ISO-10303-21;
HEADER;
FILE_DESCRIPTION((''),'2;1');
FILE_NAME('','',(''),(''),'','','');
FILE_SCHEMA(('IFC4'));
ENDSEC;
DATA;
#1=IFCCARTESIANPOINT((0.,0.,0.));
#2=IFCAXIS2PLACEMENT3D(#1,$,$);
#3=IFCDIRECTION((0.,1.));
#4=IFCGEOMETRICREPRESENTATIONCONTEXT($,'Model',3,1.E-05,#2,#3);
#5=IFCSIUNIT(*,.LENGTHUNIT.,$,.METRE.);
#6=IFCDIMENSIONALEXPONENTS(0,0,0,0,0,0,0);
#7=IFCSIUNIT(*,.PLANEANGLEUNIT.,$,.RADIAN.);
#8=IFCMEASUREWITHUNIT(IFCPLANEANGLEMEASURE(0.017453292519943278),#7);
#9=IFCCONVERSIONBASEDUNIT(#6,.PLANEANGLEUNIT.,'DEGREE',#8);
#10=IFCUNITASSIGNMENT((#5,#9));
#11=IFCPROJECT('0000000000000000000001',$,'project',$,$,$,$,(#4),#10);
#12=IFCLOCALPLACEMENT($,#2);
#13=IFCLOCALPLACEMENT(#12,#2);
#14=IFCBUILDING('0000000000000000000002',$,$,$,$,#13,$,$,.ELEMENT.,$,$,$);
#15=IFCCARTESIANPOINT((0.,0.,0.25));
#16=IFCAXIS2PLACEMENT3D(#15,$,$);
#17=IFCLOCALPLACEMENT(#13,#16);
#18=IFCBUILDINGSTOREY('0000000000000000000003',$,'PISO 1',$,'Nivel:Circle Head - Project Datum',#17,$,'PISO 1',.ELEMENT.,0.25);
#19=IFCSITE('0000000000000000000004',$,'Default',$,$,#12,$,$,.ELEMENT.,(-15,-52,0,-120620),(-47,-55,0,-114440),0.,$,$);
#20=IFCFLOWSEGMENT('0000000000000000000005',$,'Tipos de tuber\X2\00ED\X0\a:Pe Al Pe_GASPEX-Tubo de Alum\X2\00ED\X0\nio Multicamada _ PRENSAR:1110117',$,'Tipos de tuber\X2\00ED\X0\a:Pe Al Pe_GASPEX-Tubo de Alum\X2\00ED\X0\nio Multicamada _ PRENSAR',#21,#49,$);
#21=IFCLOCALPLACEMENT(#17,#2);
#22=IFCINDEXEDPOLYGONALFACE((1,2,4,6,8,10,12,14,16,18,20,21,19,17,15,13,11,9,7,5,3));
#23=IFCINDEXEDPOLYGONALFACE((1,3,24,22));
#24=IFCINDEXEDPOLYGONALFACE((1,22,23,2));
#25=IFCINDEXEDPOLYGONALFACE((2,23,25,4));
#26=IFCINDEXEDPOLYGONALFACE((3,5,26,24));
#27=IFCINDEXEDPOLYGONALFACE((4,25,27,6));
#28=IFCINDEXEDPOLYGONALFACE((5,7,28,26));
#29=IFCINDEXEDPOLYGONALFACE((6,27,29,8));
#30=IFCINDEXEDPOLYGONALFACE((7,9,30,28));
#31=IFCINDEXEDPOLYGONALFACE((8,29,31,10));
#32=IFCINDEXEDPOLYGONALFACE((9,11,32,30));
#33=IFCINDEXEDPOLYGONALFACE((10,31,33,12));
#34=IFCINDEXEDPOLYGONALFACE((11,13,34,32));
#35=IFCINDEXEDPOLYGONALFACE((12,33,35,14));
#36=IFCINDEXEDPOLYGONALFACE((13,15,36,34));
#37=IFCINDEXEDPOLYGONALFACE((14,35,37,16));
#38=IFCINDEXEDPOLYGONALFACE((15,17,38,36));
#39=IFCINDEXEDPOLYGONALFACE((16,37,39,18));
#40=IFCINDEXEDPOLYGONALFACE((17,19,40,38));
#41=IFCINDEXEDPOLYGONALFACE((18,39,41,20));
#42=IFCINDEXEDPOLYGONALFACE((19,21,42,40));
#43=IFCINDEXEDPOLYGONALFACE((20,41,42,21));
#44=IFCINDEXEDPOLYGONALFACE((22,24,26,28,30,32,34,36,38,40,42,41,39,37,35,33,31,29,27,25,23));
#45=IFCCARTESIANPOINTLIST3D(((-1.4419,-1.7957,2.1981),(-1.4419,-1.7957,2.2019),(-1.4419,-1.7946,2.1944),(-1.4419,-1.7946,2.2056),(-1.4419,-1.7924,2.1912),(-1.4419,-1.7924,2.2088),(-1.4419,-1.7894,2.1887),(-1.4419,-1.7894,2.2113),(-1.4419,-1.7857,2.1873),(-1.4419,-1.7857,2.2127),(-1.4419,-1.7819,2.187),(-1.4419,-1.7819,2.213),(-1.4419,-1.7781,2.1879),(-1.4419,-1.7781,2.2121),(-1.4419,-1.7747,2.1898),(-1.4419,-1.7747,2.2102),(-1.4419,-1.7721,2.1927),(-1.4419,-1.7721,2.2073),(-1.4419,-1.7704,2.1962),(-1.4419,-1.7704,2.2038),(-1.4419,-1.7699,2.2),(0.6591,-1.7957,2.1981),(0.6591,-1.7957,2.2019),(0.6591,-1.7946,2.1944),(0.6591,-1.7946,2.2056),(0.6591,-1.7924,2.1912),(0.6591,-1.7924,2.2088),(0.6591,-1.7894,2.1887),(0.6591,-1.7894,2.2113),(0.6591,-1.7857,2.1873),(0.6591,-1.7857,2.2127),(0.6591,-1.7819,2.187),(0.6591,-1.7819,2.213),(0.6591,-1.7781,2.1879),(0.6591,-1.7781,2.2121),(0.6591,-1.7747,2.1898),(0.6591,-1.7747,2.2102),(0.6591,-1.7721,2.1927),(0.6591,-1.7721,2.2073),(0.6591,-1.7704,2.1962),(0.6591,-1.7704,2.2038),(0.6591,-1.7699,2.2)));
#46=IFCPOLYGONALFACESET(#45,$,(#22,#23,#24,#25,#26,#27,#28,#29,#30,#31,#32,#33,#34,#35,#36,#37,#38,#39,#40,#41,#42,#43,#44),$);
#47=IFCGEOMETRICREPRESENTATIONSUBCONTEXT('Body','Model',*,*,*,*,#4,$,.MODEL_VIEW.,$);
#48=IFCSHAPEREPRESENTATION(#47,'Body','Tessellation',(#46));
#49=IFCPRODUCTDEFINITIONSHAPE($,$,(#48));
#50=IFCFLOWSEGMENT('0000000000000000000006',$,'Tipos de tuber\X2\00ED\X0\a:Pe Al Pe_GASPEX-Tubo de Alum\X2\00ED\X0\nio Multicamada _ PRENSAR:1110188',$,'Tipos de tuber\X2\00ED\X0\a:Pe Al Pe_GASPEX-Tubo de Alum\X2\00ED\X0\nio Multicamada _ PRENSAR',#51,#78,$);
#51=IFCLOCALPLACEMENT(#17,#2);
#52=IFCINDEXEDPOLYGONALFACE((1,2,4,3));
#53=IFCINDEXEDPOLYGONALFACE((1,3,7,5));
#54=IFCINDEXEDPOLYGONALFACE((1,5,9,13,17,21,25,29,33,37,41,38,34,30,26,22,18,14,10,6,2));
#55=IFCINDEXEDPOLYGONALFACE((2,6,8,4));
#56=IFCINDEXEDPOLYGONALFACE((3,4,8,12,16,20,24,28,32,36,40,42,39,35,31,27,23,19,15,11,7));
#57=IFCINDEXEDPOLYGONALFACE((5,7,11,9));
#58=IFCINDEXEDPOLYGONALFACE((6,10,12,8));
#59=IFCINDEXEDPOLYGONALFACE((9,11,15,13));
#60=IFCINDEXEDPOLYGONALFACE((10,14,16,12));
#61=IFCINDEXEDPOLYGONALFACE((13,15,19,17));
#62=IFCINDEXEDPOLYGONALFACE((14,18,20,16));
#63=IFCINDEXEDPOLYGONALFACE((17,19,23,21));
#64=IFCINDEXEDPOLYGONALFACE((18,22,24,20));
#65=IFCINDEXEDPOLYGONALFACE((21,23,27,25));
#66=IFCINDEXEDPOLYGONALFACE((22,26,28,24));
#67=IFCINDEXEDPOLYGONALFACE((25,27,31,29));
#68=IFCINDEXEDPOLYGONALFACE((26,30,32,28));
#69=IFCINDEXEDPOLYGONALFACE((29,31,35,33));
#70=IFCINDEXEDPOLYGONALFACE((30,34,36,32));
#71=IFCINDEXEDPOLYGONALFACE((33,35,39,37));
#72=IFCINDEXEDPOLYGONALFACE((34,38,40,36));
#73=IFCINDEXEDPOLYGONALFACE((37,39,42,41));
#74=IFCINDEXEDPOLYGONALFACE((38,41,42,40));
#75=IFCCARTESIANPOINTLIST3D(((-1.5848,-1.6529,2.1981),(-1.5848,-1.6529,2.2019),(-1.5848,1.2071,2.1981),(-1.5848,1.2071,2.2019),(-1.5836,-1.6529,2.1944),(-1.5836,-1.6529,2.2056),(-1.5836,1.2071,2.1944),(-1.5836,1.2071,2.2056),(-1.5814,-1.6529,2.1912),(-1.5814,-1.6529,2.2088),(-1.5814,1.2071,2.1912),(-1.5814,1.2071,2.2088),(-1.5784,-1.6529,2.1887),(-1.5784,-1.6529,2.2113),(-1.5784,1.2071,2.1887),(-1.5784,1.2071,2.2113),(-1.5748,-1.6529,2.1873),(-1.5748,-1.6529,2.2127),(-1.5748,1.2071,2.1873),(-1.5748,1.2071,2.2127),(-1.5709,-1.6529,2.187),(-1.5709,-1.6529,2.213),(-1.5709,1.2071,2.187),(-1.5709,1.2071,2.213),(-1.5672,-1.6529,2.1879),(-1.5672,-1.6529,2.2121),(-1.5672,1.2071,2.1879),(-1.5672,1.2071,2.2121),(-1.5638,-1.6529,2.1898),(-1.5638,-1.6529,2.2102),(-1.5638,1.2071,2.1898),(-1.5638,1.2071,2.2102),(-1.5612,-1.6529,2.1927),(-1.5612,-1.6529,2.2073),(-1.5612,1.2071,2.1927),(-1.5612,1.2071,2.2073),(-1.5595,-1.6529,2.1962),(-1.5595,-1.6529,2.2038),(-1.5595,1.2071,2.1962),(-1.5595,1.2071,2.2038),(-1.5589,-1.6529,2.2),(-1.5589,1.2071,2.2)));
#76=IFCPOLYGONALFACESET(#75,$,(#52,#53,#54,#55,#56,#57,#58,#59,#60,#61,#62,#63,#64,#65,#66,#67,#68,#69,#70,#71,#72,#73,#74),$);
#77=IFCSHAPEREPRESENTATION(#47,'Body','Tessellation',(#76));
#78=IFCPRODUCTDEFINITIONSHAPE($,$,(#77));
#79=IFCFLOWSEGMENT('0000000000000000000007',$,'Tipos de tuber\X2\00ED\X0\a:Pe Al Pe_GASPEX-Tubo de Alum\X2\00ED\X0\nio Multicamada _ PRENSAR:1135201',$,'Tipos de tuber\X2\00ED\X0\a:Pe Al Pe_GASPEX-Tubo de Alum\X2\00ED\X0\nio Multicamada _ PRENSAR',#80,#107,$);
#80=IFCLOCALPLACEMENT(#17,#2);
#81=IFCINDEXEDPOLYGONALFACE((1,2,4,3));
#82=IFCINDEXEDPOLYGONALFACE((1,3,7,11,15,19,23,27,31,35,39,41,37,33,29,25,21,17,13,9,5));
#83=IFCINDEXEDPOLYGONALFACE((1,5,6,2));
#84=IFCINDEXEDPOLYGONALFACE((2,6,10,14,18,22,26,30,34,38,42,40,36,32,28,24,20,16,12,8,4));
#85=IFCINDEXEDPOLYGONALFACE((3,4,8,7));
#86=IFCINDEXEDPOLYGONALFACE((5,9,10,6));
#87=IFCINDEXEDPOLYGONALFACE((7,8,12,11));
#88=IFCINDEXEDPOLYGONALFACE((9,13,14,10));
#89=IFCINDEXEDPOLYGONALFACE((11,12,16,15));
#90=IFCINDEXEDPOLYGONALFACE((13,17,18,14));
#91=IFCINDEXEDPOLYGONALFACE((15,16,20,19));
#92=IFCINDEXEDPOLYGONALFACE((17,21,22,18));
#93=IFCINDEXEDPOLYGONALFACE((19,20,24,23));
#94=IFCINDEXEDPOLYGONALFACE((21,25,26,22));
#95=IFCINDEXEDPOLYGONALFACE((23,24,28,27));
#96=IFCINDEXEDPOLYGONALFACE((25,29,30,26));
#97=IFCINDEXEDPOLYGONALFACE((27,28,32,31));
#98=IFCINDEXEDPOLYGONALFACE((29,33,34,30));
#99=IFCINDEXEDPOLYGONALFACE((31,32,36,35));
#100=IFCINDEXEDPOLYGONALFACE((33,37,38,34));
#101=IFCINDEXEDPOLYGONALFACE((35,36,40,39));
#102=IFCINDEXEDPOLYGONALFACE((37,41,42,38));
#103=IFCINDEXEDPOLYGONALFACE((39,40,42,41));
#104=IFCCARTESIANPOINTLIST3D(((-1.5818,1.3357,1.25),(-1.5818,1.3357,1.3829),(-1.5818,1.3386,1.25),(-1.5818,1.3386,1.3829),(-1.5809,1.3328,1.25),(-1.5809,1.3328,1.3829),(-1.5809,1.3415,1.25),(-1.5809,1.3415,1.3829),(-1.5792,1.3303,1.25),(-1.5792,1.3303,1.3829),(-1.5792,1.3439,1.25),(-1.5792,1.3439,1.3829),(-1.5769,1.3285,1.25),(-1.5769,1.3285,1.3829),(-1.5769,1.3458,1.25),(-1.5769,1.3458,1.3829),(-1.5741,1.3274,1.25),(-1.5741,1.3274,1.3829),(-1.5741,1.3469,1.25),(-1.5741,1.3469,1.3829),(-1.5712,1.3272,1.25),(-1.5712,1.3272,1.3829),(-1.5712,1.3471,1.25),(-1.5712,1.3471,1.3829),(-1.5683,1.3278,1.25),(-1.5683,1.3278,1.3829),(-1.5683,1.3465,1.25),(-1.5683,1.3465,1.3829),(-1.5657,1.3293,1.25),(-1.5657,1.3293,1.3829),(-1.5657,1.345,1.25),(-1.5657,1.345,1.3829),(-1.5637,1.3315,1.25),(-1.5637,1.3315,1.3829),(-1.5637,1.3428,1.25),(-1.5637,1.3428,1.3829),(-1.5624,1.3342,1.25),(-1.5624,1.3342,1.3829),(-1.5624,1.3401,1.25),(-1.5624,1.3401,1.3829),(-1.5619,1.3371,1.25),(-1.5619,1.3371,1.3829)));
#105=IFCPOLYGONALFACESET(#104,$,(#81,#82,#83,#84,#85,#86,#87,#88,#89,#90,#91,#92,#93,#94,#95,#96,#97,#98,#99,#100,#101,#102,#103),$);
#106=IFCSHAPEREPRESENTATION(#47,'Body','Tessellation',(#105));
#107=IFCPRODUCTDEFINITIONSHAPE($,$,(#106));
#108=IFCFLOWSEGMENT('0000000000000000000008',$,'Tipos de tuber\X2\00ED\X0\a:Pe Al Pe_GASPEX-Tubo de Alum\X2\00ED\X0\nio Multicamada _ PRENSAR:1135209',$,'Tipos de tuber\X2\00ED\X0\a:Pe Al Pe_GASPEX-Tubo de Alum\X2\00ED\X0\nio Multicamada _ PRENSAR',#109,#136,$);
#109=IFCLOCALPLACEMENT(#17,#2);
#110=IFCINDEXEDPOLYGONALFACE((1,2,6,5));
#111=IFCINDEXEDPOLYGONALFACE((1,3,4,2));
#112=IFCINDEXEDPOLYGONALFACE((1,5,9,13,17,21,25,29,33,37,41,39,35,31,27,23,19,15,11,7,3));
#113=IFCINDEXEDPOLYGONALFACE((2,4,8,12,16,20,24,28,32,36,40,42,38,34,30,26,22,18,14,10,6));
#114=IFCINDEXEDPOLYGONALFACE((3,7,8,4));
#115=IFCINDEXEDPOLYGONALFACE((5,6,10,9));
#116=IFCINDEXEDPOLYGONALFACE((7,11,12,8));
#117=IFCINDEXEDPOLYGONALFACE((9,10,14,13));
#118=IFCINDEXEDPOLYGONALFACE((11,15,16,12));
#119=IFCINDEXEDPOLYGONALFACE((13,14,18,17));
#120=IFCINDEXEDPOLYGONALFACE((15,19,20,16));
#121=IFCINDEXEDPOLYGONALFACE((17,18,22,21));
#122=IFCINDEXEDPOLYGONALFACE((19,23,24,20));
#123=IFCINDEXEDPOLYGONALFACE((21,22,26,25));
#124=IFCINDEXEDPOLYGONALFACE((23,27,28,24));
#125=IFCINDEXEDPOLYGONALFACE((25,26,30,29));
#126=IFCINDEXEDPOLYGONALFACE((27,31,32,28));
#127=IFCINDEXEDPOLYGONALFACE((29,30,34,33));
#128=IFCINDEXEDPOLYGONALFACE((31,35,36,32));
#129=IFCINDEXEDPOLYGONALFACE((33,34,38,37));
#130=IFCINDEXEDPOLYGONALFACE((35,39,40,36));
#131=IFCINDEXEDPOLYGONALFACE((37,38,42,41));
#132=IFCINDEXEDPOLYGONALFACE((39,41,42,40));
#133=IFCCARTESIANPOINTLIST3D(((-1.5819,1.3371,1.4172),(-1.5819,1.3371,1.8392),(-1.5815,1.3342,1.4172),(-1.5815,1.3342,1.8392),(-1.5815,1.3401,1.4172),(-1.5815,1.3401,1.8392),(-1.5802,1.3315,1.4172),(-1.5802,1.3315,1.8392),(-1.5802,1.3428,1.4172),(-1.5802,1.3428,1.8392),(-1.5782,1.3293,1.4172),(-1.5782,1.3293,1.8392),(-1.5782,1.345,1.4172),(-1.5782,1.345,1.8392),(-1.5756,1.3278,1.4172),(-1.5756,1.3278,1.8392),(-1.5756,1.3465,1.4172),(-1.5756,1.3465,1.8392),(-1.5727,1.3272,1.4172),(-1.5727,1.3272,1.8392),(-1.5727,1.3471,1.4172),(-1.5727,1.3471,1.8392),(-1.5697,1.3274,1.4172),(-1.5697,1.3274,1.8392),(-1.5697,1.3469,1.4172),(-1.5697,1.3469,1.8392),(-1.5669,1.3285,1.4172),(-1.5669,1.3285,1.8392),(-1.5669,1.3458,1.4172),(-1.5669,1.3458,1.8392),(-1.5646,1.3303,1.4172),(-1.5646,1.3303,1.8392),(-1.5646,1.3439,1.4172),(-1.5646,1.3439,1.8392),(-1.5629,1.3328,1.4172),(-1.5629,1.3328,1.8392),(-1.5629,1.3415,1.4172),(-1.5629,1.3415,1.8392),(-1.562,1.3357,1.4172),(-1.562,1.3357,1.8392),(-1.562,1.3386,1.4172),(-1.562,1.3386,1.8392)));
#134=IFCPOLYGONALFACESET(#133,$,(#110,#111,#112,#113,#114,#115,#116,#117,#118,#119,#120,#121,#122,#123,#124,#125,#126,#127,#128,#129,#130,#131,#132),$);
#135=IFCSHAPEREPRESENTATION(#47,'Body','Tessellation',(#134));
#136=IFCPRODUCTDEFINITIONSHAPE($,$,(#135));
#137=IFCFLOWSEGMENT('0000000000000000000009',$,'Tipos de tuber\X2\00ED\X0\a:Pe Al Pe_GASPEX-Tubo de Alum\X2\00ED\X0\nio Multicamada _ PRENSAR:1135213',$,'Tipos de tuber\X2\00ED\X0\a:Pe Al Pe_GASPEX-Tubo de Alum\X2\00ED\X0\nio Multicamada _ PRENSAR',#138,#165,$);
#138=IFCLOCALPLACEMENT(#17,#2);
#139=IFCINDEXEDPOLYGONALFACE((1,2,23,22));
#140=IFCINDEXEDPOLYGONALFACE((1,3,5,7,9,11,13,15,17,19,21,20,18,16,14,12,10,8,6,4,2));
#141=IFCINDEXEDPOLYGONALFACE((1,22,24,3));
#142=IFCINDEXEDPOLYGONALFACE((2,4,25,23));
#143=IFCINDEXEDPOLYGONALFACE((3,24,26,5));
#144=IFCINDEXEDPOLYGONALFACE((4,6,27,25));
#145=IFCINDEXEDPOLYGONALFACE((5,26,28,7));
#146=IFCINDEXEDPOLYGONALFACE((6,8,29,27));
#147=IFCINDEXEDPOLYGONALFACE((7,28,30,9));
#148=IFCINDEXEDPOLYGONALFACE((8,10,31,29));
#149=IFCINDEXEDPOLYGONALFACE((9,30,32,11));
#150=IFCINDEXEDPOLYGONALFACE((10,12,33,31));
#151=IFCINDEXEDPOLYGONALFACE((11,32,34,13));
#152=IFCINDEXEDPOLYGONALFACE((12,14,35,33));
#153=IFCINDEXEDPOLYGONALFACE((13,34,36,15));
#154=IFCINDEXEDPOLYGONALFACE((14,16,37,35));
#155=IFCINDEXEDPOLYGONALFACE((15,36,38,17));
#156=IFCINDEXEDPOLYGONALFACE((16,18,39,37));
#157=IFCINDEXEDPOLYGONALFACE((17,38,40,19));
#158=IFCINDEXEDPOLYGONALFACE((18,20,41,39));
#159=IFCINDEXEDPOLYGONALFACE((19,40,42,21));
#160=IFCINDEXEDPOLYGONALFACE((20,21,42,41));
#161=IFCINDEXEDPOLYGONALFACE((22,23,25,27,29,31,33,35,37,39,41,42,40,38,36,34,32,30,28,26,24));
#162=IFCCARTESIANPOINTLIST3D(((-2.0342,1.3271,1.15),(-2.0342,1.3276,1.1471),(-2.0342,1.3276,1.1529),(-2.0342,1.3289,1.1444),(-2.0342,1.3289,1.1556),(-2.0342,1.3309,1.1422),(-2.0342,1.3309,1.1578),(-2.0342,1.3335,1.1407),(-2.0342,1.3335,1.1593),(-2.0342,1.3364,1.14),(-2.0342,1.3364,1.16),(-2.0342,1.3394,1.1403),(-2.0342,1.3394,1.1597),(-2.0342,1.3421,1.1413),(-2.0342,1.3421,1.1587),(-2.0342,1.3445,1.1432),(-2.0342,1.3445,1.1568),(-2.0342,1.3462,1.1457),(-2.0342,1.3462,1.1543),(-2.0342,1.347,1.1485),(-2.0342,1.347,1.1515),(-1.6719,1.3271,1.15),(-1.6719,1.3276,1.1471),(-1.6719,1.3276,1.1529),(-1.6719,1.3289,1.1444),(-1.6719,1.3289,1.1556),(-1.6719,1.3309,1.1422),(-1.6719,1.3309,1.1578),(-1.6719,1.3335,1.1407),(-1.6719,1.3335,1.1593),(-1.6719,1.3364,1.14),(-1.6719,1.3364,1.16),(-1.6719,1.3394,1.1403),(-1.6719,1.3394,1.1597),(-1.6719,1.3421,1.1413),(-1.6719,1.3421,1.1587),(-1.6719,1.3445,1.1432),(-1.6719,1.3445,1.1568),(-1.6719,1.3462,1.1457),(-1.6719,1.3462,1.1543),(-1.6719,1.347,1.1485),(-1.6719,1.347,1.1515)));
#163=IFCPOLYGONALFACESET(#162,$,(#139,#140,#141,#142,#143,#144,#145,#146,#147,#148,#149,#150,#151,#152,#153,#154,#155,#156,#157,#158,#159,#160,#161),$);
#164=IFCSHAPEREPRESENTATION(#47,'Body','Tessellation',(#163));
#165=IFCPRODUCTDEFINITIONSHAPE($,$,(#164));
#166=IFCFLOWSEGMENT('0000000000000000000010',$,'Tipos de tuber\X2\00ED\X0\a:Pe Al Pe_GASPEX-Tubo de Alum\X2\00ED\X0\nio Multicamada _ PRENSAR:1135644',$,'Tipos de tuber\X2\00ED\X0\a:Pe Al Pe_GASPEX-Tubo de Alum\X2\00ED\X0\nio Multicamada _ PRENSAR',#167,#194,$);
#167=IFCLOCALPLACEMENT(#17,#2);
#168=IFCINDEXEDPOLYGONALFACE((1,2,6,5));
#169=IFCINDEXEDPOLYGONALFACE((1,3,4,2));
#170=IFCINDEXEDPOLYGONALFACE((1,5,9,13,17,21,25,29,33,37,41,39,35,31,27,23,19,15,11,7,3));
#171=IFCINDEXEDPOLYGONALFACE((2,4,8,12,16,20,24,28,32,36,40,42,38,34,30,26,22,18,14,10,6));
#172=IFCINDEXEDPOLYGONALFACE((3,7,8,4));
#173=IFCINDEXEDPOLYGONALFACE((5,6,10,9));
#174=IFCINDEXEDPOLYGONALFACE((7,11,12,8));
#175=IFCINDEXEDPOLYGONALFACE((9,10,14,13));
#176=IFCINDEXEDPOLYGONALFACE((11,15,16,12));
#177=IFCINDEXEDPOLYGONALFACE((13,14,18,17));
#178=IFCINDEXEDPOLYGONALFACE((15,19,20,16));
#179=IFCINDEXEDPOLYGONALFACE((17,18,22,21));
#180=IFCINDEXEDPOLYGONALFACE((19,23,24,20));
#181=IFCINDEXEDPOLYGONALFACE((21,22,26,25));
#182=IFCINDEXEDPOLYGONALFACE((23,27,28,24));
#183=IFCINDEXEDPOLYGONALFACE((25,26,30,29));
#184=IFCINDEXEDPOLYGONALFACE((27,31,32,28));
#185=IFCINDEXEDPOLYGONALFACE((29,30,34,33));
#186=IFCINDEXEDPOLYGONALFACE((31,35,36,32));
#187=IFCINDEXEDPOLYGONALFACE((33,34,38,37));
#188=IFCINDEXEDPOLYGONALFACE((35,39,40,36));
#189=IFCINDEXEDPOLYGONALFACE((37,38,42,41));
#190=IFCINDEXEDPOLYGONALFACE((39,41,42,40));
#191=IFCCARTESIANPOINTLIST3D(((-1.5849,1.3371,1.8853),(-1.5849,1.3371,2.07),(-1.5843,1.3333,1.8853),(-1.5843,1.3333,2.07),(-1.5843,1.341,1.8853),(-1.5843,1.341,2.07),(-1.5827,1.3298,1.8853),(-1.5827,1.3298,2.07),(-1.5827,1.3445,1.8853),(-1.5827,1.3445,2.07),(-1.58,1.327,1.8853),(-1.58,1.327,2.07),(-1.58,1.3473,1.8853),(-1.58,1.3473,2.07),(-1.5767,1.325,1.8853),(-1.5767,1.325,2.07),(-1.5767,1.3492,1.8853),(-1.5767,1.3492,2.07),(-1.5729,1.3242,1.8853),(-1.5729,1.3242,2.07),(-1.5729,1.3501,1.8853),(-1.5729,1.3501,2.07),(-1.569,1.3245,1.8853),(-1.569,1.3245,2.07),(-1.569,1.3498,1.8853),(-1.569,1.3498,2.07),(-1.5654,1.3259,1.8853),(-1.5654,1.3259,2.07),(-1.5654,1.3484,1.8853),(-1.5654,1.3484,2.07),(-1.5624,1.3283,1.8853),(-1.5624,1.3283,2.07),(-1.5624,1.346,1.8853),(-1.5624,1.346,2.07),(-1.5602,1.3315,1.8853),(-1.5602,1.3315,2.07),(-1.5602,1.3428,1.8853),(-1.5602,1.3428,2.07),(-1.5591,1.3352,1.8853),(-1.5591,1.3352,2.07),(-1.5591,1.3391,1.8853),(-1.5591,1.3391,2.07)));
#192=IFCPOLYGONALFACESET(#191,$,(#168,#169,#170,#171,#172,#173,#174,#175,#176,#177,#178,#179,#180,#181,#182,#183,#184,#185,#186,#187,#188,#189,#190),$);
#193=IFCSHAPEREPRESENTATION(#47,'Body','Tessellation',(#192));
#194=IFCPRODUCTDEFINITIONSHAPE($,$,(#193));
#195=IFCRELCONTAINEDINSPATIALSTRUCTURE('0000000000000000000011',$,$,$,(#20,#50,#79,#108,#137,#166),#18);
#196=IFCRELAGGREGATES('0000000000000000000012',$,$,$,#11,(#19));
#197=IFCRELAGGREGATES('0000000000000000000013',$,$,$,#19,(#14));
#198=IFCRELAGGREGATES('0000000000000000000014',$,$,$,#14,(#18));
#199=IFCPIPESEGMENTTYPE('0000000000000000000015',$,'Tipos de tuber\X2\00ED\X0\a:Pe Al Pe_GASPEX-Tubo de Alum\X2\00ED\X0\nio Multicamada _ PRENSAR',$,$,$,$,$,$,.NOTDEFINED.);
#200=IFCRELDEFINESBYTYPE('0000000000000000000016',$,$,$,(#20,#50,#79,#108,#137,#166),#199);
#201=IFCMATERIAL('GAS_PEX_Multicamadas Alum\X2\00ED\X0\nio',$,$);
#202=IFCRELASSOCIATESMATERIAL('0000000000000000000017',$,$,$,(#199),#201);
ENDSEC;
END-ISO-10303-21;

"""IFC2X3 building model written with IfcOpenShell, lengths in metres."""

from ifc_helpers import new_model, entity, si_unit, converted_unit, direction, frame, frame_2d, origin, origin_2d_with_axis, place, context, subcontext, project, spatial, circle, extrude, material, type_object, element, save


model = new_model("IFC2X3")

# Units and contexts
model_context = context("Model", 3, precision=1e-05, world=origin(), true_north=direction((0.0, 1.0)))
body_context = subcontext(model_context, "Body", "Model", "MODEL_VIEW")
ifc_project = project(units=[si_unit("LENGTHUNIT", "METRE"), converted_unit("PLANEANGLEUNIT", "DEGREE", entity("IfcPlaneAngleMeasure", 0.017453292519943278), si_unit("PLANEANGLEUNIT", "RADIAN"), dimensions=[0, 0, 0, 0, 0, 0, 0])], contexts=[model_context])

# Site, building, storey
site_placement = place(None, origin())
site = spatial("IfcSite", under=ifc_project, at=site_placement, Name="Default", CompositionType="ELEMENT", RefLatitude=(-15, -52, 0, -120620), RefLongitude=(-47, -55, 0, -114440), RefElevation=0.0)
building_placement = place(site_placement, origin())
building = spatial("IfcBuilding", under=site, at=building_placement, CompositionType="ELEMENT")
storey_placement = place(building_placement, frame((0.0, 0.0, 0.25)))
storey = spatial("IfcBuildingStorey", under=building, at=storey_placement, Name="PISO 1", ObjectType="Nivel:Circle Head - Project Datum", LongName="PISO 1", CompositionType="ELEMENT", Elevation=0.25)

# Flow segments
ifc_material = material(Name="GAS_PEX_Multicamadas Alumínio")
pipe_segment_type = type_object("IfcPipeSegmentType", Name="Tipos de tubería:Pe Al Pe_GASPEX-Tubo de Alumínio Multicamada _ PRENSAR", PredefinedType="NOTDEFINED", material=ifc_material)
flow_segment_1_placement = place(storey_placement, origin())
element("IfcFlowSegment", 1, at=flow_segment_1_placement, inside=storey, type_object=pipe_segment_type, Name="Tipos de tubería:Pe Al Pe_GASPEX-Tubo de Alumínio Multicamada _ PRENSAR:1110117", ObjectType="Tipos de tubería:Pe Al Pe_GASPEX-Tubo de Alumínio Multicamada _ PRENSAR", context=body_context, shape_type="SweptSolid", body=[
    extrude(circle(Radius=0.013, at=origin_2d_with_axis()), frame((-1.4419, -1.7829, 2.2), z_axis=(1.0, 0.0, 0.0), x_axis=(0.0, 1.0, 0.0)), (0.0, 0.0, 1.0), 2.101),
])
flow_segment_2_placement = place(storey_placement, origin())
element("IfcFlowSegment", 2, at=flow_segment_2_placement, inside=storey, type_object=pipe_segment_type, Name="Tipos de tubería:Pe Al Pe_GASPEX-Tubo de Alumínio Multicamada _ PRENSAR:1110188", ObjectType="Tipos de tubería:Pe Al Pe_GASPEX-Tubo de Alumínio Multicamada _ PRENSAR", context=body_context, shape_type="SweptSolid", body=[
    extrude(circle(Radius=0.013, at=frame_2d((0.0, 0.0), x_axis=(1.0, 0.0))), frame((-1.5719, -1.6529, 2.2), z_axis=(0.0, 1.0, 0.0), x_axis=(1.0, 0.0, 0.0)), (0.0, 0.0, 1.0), 2.86),
])
flow_segment_3_placement = place(storey_placement, origin())
element("IfcFlowSegment", 3, at=flow_segment_3_placement, inside=storey, type_object=pipe_segment_type, Name="Tipos de tubería:Pe Al Pe_GASPEX-Tubo de Alumínio Multicamada _ PRENSAR:1135201", ObjectType="Tipos de tubería:Pe Al Pe_GASPEX-Tubo de Alumínio Multicamada _ PRENSAR", context=body_context, shape_type="SweptSolid", body=[
    extrude(circle(Radius=0.01, at=origin_2d_with_axis()), frame((-1.5719, 1.3371, 1.25)), (0.0, 0.0, 1.0), 0.1329),
])
flow_segment_4_placement = place(storey_placement, origin())
element("IfcFlowSegment", 4, at=flow_segment_4_placement, inside=storey, type_object=pipe_segment_type, Name="Tipos de tubería:Pe Al Pe_GASPEX-Tubo de Alumínio Multicamada _ PRENSAR:1135209", ObjectType="Tipos de tubería:Pe Al Pe_GASPEX-Tubo de Alumínio Multicamada _ PRENSAR", context=body_context, shape_type="SweptSolid", body=[
    extrude(circle(Radius=0.01, at=origin_2d_with_axis()), frame((-1.5719, 1.3371, 1.4172), z_axis=(0.0, 0.0, 1.0), x_axis=(-1.0, 0.0, 0.0)), (0.0, 0.0, 1.0), 0.4221),
])
flow_segment_5_placement = place(storey_placement, origin())
element("IfcFlowSegment", 5, at=flow_segment_5_placement, inside=storey, type_object=pipe_segment_type, Name="Tipos de tubería:Pe Al Pe_GASPEX-Tubo de Alumínio Multicamada _ PRENSAR:1135213", ObjectType="Tipos de tubería:Pe Al Pe_GASPEX-Tubo de Alumínio Multicamada _ PRENSAR", context=body_context, shape_type="SweptSolid", body=[
    extrude(circle(Radius=0.01, at=origin_2d_with_axis()), frame((-2.0342, 1.3371, 1.15), z_axis=(1.0, 0.0, 0.0), x_axis=(0.0, -1.0, 0.0)), (0.0, 0.0, 1.0), 0.3623),
])
flow_segment_6_placement = place(storey_placement, origin())
element("IfcFlowSegment", 6, at=flow_segment_6_placement, inside=storey, type_object=pipe_segment_type, Name="Tipos de tubería:Pe Al Pe_GASPEX-Tubo de Alumínio Multicamada _ PRENSAR:1135644", ObjectType="Tipos de tubería:Pe Al Pe_GASPEX-Tubo de Alumínio Multicamada _ PRENSAR", context=body_context, shape_type="SweptSolid", body=[
    extrude(circle(Radius=0.013, at=origin_2d_with_axis()), frame((-1.5719, 1.3371, 1.8853), z_axis=(0.0, 0.0, 1.0), x_axis=(-1.0, 0.0, 0.0)), (0.0, 0.0, 1.0), 0.1847),
])

save(model, "model.ifc")
